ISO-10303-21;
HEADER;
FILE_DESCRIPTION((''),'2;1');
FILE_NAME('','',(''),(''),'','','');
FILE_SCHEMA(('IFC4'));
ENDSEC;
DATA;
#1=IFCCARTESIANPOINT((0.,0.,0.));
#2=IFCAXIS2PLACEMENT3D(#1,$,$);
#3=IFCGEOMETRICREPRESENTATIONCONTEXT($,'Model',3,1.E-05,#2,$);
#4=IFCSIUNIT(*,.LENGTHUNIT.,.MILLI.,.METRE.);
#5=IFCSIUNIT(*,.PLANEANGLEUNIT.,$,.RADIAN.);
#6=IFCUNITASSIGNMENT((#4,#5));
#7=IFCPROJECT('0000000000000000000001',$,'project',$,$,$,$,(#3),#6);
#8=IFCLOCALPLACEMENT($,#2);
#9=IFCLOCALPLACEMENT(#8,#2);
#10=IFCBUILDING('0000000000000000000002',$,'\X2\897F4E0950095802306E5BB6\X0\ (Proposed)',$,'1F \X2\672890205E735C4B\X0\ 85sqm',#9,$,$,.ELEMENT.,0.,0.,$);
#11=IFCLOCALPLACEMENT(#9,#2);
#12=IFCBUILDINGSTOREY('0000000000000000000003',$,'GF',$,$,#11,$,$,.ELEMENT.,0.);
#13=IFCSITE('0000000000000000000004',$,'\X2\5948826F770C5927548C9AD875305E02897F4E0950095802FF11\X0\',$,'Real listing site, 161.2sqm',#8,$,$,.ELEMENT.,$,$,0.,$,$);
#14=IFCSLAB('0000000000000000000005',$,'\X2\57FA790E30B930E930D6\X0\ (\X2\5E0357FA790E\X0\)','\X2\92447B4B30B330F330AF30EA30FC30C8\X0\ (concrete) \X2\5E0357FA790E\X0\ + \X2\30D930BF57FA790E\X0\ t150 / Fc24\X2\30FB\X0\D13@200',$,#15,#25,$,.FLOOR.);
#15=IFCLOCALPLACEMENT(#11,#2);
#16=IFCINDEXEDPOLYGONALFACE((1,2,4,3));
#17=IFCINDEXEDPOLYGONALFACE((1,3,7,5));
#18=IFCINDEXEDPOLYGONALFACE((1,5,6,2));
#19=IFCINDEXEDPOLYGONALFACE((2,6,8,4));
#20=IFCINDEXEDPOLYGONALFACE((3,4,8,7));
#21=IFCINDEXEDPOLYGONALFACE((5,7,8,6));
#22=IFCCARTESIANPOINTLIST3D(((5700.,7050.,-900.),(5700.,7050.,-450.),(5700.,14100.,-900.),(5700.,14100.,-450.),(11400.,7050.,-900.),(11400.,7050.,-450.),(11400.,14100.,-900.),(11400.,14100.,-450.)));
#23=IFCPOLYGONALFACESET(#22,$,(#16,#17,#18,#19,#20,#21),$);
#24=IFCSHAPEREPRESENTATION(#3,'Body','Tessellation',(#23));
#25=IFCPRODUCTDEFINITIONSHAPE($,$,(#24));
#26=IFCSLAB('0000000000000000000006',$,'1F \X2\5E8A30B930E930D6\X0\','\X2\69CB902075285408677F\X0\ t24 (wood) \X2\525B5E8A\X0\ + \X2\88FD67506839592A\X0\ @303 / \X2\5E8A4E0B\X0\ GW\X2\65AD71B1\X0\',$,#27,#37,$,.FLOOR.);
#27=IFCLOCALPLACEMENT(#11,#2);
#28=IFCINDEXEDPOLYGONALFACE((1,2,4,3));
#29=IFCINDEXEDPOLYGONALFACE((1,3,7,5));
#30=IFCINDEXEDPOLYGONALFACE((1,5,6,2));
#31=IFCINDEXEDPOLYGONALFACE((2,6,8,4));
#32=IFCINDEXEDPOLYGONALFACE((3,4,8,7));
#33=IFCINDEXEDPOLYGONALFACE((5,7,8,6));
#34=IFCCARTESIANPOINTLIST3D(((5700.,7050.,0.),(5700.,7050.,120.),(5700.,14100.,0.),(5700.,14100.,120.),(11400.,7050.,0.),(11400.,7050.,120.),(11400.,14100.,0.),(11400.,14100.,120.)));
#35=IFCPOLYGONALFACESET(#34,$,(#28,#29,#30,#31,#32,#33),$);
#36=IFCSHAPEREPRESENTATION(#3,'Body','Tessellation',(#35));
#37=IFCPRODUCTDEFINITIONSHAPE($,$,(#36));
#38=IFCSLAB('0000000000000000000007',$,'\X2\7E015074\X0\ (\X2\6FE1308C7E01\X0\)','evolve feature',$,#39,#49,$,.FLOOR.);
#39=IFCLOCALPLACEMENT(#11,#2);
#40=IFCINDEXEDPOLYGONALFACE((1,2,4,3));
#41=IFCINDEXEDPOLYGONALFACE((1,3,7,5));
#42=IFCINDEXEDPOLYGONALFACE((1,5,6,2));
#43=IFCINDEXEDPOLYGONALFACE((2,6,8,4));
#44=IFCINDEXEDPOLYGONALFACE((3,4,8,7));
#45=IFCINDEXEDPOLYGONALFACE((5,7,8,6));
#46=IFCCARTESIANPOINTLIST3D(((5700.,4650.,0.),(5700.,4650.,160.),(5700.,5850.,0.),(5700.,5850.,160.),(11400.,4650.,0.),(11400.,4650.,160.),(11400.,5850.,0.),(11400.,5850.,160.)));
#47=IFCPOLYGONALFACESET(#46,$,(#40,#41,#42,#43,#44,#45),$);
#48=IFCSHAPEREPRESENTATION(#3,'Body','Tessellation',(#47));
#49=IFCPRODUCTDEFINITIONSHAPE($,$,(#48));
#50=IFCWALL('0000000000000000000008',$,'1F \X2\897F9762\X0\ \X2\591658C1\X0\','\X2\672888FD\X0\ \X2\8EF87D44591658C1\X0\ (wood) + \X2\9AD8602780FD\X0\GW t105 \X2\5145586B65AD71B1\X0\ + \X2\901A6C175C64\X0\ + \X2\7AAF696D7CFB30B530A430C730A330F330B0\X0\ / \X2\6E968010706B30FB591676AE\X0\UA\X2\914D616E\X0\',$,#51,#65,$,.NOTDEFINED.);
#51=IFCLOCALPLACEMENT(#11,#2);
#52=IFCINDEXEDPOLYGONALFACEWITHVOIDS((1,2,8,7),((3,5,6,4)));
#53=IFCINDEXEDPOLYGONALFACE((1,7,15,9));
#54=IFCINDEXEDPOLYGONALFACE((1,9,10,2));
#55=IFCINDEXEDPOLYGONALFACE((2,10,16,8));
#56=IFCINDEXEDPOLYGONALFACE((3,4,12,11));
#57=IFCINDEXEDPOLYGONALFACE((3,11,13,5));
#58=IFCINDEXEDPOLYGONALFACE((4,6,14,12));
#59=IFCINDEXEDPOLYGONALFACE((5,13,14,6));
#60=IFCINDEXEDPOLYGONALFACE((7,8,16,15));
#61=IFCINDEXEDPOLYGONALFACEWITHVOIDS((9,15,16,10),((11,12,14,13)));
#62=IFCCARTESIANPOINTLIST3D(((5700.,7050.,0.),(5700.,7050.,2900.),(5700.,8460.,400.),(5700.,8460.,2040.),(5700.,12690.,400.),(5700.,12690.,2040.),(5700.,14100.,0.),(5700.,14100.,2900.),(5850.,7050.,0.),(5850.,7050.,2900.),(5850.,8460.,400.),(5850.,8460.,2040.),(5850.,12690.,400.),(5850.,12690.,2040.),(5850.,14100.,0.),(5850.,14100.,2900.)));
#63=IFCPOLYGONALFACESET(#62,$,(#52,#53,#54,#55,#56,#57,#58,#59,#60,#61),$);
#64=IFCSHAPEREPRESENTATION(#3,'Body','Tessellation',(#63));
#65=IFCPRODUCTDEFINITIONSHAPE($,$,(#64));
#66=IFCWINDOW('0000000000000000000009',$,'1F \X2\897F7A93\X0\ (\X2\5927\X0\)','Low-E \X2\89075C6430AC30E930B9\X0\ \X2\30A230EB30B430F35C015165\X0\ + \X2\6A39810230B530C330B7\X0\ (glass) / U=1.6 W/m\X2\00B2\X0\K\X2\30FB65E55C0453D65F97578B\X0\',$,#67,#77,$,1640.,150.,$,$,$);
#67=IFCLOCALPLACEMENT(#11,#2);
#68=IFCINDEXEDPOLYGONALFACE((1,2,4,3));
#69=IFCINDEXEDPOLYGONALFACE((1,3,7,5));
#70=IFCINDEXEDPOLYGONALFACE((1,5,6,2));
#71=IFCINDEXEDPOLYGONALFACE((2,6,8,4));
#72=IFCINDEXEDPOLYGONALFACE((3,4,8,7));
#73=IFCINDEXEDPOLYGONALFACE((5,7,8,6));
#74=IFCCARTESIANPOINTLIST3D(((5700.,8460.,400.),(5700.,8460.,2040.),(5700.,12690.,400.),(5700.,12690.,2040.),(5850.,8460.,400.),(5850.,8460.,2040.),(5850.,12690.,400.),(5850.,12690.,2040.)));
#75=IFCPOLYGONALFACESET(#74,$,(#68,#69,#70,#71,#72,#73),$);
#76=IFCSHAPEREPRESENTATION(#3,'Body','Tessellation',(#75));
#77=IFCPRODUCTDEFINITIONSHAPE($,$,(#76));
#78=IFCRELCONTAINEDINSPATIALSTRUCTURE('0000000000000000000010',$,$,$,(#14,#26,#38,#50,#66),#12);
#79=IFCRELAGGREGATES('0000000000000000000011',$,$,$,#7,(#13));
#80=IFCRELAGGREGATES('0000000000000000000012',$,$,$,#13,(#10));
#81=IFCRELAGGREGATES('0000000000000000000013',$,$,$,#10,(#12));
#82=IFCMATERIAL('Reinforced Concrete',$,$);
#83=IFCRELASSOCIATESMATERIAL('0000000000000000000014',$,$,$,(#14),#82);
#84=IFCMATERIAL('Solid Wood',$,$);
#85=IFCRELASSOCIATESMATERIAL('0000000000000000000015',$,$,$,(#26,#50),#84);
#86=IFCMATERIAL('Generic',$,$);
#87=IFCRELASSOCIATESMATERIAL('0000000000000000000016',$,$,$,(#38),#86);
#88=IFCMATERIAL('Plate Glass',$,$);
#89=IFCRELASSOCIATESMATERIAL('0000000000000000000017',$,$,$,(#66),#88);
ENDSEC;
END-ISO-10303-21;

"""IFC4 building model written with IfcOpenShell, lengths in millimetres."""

from ifc_helpers import new_model, si_unit, frame, frame_2d, origin, place, context, project, spatial, rectangle, extrude, material, element, fill, save


model = new_model("IFC4")

# Units and contexts
model_context = context("Model", 3, precision=1e-05, world=origin())
ifc_project = project(units=[si_unit("LENGTHUNIT", "METRE", prefix="MILLI"), si_unit("PLANEANGLEUNIT", "RADIAN")], contexts=[model_context])

# Site, building, storey
site_placement = place(None, origin())
site = spatial("IfcSite", under=ifc_project, at=site_placement, Name="奈良県大和高田市西三倉堂１", ObjectType="Real listing site, 161.2sqm", CompositionType="ELEMENT", RefElevation=0.0)
building_placement = place(site_placement, origin())
building = spatial("IfcBuilding", under=site, at=building_placement, Name="西三倉堂の家 (Proposed)", ObjectType="1F 木造平屋 85sqm", CompositionType="ELEMENT", ElevationOfRefHeight=0.0, ElevationOfTerrain=0.0)
storey_placement = place(building_placement, origin())
storey = spatial("IfcBuildingStorey", under=building, at=storey_placement, Name="GF", CompositionType="ELEMENT", Elevation=0.0)

# Slabs
ifc_material_1 = material(Name="Reinforced Concrete")
slab_1_placement = place(storey_placement, frame((2850.0, 3525.0, -450.0)))
element("IfcSlab", 1, at=slab_1_placement, inside=storey, material=ifc_material_1, Name="基礎スラブ (布基礎)", Description="鉄筋コンクリート (concrete) 布基礎 + ベタ基礎 t150 / Fc24・D13@200", PredefinedType="FLOOR", context=model_context, shape_type="SweptSolid", body=[
    extrude(rectangle(XDim=5700.0, YDim=7050.0, at=frame_2d((2850.0, 3525.0))), frame((2850.0, 3525.0, -450.0)), (0.0, 0.0, 1.0), 450.0),
])
ifc_material_2 = material(Name="Solid Wood")
slab_2_placement = place(storey_placement, frame((2850.0, 3525.0, 0.0)))
element("IfcSlab", 2, at=slab_2_placement, inside=storey, material=ifc_material_2, Name="1F 床スラブ", Description="構造用合板 t24 (wood) 剛床 + 製材根太 @303 / 床下 GW断熱", PredefinedType="FLOOR", context=model_context, shape_type="SweptSolid", body=[
    extrude(rectangle(XDim=5700.0, YDim=7050.0, at=frame_2d((2850.0, 3525.0))), frame((2850.0, 3525.0, 0.0)), (0.0, 0.0, 1.0), 120.0),
])
ifc_material_3 = material(Name="Generic")
slab_3_placement = place(storey_placement, frame((2850.0, 2325.0, 0.0)))
element("IfcSlab", 3, at=slab_3_placement, inside=storey, material=ifc_material_3, Name="縁側 (濡れ縁)", Description="evolve feature", PredefinedType="FLOOR", context=model_context, shape_type="SweptSolid", body=[
    extrude(rectangle(XDim=5700.0, YDim=1200.0, at=frame_2d((2850.0, 600.0))), frame((2850.0, 2325.0, 0.0)), (0.0, 0.0, 1.0), 160.0),
])

# Shared definitions
ifc_material_4 = material(Name="Plate Glass")

# Wall, opening, window
wall_1_placement = place(storey_placement, frame((2850.0, 3525.0, 0.0)))
wall_1 = element("IfcWall", 4, at=wall_1_placement, inside=storey, material=ifc_material_2, Name="1F 西面 外壁", Description="木製 軸組外壁 (wood) + 高性能GW t105 充填断熱 + 通気層 + 窯業系サイディング / 準耐火・外皮UA配慮", PredefinedType="NOTDEFINED", context=model_context, shape_type="SweptSolid", body=[
    extrude(rectangle(XDim=150.0, YDim=7050.0, at=frame_2d((75.0, 3525.0))), frame((2850.0, 3525.0, 0.0)), (0.0, 0.0, 1.0), 2900.0),
])
opening_1_placement = place(storey_placement, frame((2850.0, 4230.0, 200.0)))
opening_1 = element("IfcOpeningElement", 5, at=opening_1_placement, cuts=wall_1, PredefinedType="NOTDEFINED", context=model_context, shape_type="SweptSolid", body=[
    extrude(rectangle(XDim=150.0, YDim=4230.0, at=frame_2d((75.0, 2115.0))), frame((2850.0, 4230.0, 200.0)), (0.0, 0.0, 1.0), 1640.0),
])
window_1_placement = place(storey_placement, frame((2850.0, 4230.0, 200.0)))
window_1 = element("IfcWindow", 6, at=window_1_placement, inside=storey, material=ifc_material_4, Name="1F 西窓 (大)", Description="Low-E 複層ガラス アルゴン封入 + 樹脂サッシ (glass) / U=1.6 W/m²K・日射取得型", OverallHeight=1640.0, OverallWidth=150.0, context=model_context, shape_type="SweptSolid", body=[
    extrude(rectangle(XDim=150.0, YDim=4230.0, at=frame_2d((75.0, 2115.0))), frame((2850.0, 4230.0, 200.0)), (0.0, 0.0, 1.0), 1640.0),
])
fill(opening_1, window_1)

save(model, "model.ifc")
